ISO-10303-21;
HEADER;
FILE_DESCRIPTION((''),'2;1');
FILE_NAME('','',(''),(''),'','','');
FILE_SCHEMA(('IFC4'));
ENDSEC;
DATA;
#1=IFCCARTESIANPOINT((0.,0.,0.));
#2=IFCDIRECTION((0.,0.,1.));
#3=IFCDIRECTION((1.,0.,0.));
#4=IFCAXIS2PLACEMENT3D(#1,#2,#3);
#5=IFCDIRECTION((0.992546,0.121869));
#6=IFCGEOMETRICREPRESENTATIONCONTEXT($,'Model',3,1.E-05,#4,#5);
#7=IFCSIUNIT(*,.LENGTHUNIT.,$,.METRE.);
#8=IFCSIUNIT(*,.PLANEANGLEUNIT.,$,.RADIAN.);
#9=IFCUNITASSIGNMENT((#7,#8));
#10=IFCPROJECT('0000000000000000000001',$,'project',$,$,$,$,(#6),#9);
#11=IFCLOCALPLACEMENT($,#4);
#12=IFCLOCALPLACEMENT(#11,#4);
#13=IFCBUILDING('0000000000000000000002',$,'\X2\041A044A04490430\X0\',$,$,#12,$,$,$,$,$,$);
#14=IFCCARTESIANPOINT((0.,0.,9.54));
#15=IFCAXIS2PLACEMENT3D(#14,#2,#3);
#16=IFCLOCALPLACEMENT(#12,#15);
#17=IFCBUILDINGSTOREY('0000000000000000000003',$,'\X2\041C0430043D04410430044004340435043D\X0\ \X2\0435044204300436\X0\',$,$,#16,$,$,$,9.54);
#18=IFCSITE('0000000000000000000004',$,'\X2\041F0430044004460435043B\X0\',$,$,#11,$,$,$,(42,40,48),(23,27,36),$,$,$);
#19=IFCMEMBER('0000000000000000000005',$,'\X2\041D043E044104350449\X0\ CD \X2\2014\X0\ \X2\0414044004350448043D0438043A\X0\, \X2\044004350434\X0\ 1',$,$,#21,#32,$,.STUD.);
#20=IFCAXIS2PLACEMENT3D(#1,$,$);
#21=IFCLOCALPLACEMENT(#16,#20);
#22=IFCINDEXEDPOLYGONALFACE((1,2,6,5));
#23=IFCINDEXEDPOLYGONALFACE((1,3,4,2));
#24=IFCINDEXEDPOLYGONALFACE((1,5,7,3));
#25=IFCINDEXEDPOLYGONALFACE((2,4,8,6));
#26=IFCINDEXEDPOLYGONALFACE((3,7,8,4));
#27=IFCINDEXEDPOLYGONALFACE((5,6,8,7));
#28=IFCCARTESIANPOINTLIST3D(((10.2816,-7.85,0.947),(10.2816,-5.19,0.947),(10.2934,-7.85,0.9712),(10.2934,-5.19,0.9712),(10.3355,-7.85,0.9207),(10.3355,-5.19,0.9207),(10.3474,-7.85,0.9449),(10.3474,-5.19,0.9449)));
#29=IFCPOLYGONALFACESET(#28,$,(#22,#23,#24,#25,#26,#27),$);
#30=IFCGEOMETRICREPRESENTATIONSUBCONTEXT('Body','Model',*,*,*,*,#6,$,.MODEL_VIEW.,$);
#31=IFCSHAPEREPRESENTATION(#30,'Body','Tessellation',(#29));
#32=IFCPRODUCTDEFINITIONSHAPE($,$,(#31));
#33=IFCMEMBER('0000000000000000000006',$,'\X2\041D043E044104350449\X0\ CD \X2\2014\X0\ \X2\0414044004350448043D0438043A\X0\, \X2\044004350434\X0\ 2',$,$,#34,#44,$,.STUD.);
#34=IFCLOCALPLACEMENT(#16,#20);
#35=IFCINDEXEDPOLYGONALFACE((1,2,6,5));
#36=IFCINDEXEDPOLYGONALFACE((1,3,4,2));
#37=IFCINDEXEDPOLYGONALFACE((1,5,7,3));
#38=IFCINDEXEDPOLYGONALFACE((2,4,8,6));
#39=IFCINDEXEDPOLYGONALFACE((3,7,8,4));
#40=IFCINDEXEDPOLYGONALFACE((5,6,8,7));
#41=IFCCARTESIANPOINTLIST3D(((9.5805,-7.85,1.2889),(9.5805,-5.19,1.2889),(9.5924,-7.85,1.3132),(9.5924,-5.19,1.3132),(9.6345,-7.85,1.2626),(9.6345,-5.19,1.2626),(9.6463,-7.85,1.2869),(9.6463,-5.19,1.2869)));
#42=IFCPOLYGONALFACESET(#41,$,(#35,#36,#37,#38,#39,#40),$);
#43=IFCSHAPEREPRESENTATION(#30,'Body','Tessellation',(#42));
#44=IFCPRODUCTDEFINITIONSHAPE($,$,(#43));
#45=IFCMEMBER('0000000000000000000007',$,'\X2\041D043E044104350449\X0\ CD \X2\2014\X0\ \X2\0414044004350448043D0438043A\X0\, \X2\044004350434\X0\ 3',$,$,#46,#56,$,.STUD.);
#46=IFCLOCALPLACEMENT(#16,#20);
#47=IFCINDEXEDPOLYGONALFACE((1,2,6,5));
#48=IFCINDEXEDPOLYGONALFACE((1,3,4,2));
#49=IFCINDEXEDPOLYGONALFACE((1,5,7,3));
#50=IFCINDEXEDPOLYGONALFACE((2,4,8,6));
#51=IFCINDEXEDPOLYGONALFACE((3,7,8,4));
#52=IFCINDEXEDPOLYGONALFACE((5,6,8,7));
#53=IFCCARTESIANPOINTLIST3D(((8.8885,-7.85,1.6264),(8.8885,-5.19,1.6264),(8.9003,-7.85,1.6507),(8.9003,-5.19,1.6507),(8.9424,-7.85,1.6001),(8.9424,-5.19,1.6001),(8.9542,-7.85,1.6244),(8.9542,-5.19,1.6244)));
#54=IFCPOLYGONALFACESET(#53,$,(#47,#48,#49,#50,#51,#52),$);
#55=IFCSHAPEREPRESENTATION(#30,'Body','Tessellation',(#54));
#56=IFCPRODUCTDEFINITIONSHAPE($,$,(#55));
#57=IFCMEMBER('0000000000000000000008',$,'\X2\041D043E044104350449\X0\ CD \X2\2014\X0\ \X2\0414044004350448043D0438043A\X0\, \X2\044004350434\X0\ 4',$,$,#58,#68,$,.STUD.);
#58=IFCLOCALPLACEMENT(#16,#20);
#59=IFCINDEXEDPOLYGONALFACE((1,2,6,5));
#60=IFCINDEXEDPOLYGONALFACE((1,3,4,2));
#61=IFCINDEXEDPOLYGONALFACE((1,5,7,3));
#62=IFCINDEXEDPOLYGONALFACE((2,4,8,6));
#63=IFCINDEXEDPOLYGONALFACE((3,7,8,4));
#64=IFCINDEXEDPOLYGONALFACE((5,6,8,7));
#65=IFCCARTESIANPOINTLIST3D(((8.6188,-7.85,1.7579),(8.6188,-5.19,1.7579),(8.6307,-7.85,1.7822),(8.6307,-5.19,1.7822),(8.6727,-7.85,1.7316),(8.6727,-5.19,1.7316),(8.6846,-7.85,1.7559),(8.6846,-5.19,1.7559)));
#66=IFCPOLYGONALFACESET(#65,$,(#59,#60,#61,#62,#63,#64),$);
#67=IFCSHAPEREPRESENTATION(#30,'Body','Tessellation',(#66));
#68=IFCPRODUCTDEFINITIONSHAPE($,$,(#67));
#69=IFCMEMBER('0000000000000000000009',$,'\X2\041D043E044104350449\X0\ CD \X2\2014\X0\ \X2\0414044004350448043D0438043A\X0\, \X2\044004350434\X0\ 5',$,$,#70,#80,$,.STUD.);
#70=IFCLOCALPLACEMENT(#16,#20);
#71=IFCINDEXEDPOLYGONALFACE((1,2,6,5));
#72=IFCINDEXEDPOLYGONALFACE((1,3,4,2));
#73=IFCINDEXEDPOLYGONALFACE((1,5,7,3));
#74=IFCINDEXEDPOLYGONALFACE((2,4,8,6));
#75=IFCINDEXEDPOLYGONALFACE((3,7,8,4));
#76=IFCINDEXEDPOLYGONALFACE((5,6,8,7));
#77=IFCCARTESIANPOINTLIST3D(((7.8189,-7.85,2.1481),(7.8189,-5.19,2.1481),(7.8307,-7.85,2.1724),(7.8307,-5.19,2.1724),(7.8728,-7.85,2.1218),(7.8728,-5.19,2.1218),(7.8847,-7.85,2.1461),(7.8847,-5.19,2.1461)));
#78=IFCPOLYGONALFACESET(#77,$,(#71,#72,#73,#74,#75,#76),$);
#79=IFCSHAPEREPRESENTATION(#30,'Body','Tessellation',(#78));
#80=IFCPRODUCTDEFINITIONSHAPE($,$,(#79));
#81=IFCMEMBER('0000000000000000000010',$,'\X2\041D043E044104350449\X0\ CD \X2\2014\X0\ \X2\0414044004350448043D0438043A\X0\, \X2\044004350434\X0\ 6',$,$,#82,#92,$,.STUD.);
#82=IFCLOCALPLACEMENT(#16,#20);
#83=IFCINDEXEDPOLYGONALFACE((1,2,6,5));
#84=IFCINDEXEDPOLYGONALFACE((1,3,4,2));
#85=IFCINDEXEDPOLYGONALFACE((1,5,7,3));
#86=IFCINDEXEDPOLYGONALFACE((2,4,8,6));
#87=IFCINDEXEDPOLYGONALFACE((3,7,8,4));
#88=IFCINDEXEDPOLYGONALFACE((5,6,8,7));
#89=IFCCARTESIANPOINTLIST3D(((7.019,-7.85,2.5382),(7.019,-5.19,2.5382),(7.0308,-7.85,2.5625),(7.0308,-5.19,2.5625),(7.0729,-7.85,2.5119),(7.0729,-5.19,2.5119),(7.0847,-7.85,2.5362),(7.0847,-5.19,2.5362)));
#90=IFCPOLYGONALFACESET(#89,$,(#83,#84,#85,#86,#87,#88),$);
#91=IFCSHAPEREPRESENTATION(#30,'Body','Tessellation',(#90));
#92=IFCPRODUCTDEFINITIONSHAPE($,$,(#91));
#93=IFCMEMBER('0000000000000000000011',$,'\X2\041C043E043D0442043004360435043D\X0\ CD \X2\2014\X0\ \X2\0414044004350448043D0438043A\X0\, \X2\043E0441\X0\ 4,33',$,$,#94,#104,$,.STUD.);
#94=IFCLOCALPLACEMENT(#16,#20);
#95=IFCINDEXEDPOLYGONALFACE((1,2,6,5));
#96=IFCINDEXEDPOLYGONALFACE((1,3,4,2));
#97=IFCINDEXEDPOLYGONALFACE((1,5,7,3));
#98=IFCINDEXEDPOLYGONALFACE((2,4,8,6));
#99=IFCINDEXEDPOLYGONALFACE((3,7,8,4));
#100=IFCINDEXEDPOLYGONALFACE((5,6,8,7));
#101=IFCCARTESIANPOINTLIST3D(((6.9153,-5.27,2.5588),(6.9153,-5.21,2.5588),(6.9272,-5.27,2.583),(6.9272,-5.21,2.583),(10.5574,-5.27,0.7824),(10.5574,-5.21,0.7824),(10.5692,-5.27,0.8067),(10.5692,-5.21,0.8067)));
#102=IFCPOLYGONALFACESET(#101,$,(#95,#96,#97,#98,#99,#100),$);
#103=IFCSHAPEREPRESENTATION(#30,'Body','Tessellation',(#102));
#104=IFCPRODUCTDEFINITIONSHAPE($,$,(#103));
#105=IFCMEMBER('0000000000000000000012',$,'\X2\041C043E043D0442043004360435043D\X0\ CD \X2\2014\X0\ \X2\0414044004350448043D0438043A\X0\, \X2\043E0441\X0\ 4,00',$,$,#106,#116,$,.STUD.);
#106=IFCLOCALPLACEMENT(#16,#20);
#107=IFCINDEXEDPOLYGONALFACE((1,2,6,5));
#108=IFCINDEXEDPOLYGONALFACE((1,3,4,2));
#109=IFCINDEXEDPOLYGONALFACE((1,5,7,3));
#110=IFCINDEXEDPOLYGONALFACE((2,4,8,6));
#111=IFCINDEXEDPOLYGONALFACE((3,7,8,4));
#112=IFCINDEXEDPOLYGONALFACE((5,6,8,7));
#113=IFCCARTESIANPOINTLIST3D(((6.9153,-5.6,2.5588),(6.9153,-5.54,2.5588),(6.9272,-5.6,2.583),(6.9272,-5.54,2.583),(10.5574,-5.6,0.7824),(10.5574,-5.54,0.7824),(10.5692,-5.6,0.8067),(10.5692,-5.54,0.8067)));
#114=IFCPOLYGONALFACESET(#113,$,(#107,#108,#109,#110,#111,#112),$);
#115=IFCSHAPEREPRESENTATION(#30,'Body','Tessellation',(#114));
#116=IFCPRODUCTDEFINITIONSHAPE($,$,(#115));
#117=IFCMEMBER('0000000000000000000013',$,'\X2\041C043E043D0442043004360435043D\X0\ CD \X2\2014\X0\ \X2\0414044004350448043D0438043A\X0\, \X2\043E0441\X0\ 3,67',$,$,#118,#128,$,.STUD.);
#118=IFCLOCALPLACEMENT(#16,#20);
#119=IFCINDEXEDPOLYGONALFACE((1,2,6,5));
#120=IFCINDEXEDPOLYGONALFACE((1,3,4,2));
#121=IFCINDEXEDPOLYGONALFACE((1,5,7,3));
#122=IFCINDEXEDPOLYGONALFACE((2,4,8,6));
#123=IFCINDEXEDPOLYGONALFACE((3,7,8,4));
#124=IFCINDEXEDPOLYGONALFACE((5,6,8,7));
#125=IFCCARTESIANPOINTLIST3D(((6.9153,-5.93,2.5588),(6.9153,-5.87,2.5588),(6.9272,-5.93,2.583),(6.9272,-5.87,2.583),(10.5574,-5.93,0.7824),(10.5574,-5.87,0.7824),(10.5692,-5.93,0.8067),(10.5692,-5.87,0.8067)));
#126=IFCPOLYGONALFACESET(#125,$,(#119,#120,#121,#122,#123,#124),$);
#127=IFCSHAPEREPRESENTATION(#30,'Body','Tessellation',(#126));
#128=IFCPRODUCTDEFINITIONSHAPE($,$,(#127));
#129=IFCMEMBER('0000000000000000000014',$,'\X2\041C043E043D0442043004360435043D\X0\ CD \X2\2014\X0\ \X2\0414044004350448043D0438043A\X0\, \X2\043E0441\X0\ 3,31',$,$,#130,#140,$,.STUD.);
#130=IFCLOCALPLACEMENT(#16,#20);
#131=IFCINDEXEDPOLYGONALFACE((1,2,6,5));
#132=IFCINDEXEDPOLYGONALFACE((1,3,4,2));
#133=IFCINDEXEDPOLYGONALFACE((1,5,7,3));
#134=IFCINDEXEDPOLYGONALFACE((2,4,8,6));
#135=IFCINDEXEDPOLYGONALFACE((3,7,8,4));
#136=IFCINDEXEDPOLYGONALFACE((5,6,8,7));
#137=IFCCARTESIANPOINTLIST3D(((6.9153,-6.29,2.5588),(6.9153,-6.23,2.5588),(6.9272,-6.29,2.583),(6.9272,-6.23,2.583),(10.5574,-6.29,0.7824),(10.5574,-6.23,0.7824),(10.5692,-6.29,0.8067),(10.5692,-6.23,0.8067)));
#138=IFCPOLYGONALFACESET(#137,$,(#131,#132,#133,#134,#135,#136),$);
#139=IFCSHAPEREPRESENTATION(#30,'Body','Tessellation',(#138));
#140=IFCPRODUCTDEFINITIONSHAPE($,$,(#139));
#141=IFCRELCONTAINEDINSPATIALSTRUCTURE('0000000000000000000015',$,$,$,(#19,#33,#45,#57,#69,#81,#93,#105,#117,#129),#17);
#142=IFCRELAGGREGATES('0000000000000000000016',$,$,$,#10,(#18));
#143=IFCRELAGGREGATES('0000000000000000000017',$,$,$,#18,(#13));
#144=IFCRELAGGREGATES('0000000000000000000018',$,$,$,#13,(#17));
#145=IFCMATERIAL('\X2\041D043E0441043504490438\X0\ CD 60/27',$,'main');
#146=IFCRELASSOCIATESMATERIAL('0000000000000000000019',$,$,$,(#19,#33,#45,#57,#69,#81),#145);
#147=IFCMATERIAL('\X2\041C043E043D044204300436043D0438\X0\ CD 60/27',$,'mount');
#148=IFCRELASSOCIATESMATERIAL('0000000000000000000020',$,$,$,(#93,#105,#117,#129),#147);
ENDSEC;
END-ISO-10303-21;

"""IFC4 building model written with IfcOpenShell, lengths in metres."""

from ifc_helpers import new_model, si_unit, direction, frame, origin_with_axes, place, context, subcontext, project, spatial, polyline, outline, extrude, material, element, save


model = new_model("IFC4")

# Units and contexts
model_context = context("Model", 3, precision=1e-05, world=origin_with_axes(), true_north=direction((0.992546, 0.121869)))
body_context = subcontext(model_context, "Body", "Model", "MODEL_VIEW")
ifc_project = project(units=[si_unit("LENGTHUNIT", "METRE"), si_unit("PLANEANGLEUNIT", "RADIAN")], contexts=[model_context])

# Site, building, storey
site_placement = place(None, origin_with_axes())
site = spatial("IfcSite", under=ifc_project, at=site_placement, Name="Парцел", RefLatitude=(42, 40, 48), RefLongitude=(23, 27, 36))
building_placement = place(site_placement, origin_with_axes())
building = spatial("IfcBuilding", under=site, at=building_placement, Name="Къща")
storey_placement = place(building_placement, frame((0.0, 0.0, 9.54), z_axis=(0.0, 0.0, 1.0), x_axis=(1.0, 0.0, 0.0)))
storey = spatial("IfcBuildingStorey", under=building, at=storey_placement, Name="Мансарден етаж", Elevation=9.54)

# Members
ifc_material_1 = material(Name="Монтажни CD 60/27", Category="mount")
ifc_material_2 = material(Name="Носещи CD 60/27", Category="main")
member_1_placement = place(storey_placement, origin_with_axes())
element("IfcMember", 1, at=member_1_placement, inside=storey, material=ifc_material_2, Name="Носещ CD — Дрешник, ред 1", PredefinedType="STUD", context=body_context, shape_type="SweptSolid", body=[
    extrude(outline(polyline([(10.3355, -0.9207), (10.2816, -0.947), (10.2934, -0.9712), (10.3474, -0.9449), (10.3355, -0.9207)])), frame((0.0, -7.85, 0.0), z_axis=(0.0, 1.0, 0.0), x_axis=(1.0, 0.0, 0.0)), (0.0, 0.0, 1.0), 2.66),
])
member_2_placement = place(storey_placement, origin_with_axes())
element("IfcMember", 2, at=member_2_placement, inside=storey, material=ifc_material_2, Name="Носещ CD — Дрешник, ред 2", PredefinedType="STUD", context=body_context, shape_type="SweptSolid", body=[
    extrude(outline(polyline([(9.6345, -1.2626), (9.5805, -1.2889), (9.5924, -1.3132), (9.6463, -1.2869), (9.6345, -1.2626)])), frame((0.0, -7.85, 0.0), z_axis=(0.0, 1.0, 0.0), x_axis=(1.0, 0.0, 0.0)), (0.0, 0.0, 1.0), 2.66),
])
member_3_placement = place(storey_placement, origin_with_axes())
element("IfcMember", 3, at=member_3_placement, inside=storey, material=ifc_material_2, Name="Носещ CD — Дрешник, ред 3", PredefinedType="STUD", context=body_context, shape_type="SweptSolid", body=[
    extrude(outline(polyline([(8.9424, -1.6001), (8.8885, -1.6264), (8.9003, -1.6507), (8.9542, -1.6244), (8.9424, -1.6001)])), frame((0.0, -7.85, 0.0), z_axis=(0.0, 1.0, 0.0), x_axis=(1.0, 0.0, 0.0)), (0.0, 0.0, 1.0), 2.66),
])
member_4_placement = place(storey_placement, origin_with_axes())
element("IfcMember", 4, at=member_4_placement, inside=storey, material=ifc_material_2, Name="Носещ CD — Дрешник, ред 4", PredefinedType="STUD", context=body_context, shape_type="SweptSolid", body=[
    extrude(outline(polyline([(8.6727, -1.7316), (8.6188, -1.7579), (8.6307, -1.7822), (8.6846, -1.7559), (8.6727, -1.7316)])), frame((0.0, -7.85, 0.0), z_axis=(0.0, 1.0, 0.0), x_axis=(1.0, 0.0, 0.0)), (0.0, 0.0, 1.0), 2.66),
])
member_5_placement = place(storey_placement, origin_with_axes())
element("IfcMember", 5, at=member_5_placement, inside=storey, material=ifc_material_2, Name="Носещ CD — Дрешник, ред 5", PredefinedType="STUD", context=body_context, shape_type="SweptSolid", body=[
    extrude(outline(polyline([(7.8728, -2.1218), (7.8189, -2.1481), (7.8307, -2.1724), (7.8847, -2.1461), (7.8728, -2.1218)])), frame((0.0, -7.85, 0.0), z_axis=(0.0, 1.0, 0.0), x_axis=(1.0, 0.0, 0.0)), (0.0, 0.0, 1.0), 2.66),
])
member_6_placement = place(storey_placement, origin_with_axes())
element("IfcMember", 6, at=member_6_placement, inside=storey, material=ifc_material_2, Name="Носещ CD — Дрешник, ред 6", PredefinedType="STUD", context=body_context, shape_type="SweptSolid", body=[
    extrude(outline(polyline([(7.0729, -2.5119), (7.019, -2.5383), (7.0308, -2.5625), (7.0847, -2.5362), (7.0729, -2.5119)])), frame((0.0, -7.85, 0.0), z_axis=(0.0, 1.0, 0.0), x_axis=(1.0, 0.0, 0.0)), (0.0, 0.0, 1.0), 2.66),
])
member_7_placement = place(storey_placement, origin_with_axes())
element("IfcMember", 7, at=member_7_placement, inside=storey, material=ifc_material_1, Name="Монтажен CD — Дрешник, ос 4,33", PredefinedType="STUD", context=body_context, shape_type="SweptSolid", body=[
    extrude(outline(polyline([(10.5574, -0.7824), (6.9153, -2.5587), (6.9272, -2.583), (10.5692, -0.8067), (10.5574, -0.7824)])), frame((0.0, -5.27, 0.0), z_axis=(0.0, 1.0, 0.0), x_axis=(1.0, 0.0, 0.0)), (0.0, 0.0, 1.0), 0.06),
])
member_8_placement = place(storey_placement, origin_with_axes())
element("IfcMember", 8, at=member_8_placement, inside=storey, material=ifc_material_1, Name="Монтажен CD — Дрешник, ос 4,00", PredefinedType="STUD", context=body_context, shape_type="SweptSolid", body=[
    extrude(outline(polyline([(10.5574, -0.7824), (6.9153, -2.5587), (6.9272, -2.583), (10.5692, -0.8067), (10.5574, -0.7824)])), frame((0.0, -5.6, 0.0), z_axis=(0.0, 1.0, 0.0), x_axis=(1.0, 0.0, 0.0)), (0.0, 0.0, 1.0), 0.06),
])
member_9_placement = place(storey_placement, origin_with_axes())
element("IfcMember", 9, at=member_9_placement, inside=storey, material=ifc_material_1, Name="Монтажен CD — Дрешник, ос 3,67", PredefinedType="STUD", context=body_context, shape_type="SweptSolid", body=[
    extrude(outline(polyline([(10.5574, -0.7824), (6.9153, -2.5587), (6.9272, -2.583), (10.5692, -0.8067), (10.5574, -0.7824)])), frame((0.0, -5.93, 0.0), z_axis=(0.0, 1.0, 0.0), x_axis=(1.0, 0.0, 0.0)), (0.0, 0.0, 1.0), 0.06),
])
member_10_placement = place(storey_placement, origin_with_axes())
element("IfcMember", 10, at=member_10_placement, inside=storey, material=ifc_material_1, Name="Монтажен CD — Дрешник, ос 3,31", PredefinedType="STUD", context=body_context, shape_type="SweptSolid", body=[
    extrude(outline(polyline([(10.5574, -0.7824), (6.9153, -2.5587), (6.9272, -2.583), (10.5692, -0.8067), (10.5574, -0.7824)])), frame((0.0, -6.29, 0.0), z_axis=(0.0, 1.0, 0.0), x_axis=(1.0, 0.0, 0.0)), (0.0, 0.0, 1.0), 0.06),
])

save(model, "model.ifc")
